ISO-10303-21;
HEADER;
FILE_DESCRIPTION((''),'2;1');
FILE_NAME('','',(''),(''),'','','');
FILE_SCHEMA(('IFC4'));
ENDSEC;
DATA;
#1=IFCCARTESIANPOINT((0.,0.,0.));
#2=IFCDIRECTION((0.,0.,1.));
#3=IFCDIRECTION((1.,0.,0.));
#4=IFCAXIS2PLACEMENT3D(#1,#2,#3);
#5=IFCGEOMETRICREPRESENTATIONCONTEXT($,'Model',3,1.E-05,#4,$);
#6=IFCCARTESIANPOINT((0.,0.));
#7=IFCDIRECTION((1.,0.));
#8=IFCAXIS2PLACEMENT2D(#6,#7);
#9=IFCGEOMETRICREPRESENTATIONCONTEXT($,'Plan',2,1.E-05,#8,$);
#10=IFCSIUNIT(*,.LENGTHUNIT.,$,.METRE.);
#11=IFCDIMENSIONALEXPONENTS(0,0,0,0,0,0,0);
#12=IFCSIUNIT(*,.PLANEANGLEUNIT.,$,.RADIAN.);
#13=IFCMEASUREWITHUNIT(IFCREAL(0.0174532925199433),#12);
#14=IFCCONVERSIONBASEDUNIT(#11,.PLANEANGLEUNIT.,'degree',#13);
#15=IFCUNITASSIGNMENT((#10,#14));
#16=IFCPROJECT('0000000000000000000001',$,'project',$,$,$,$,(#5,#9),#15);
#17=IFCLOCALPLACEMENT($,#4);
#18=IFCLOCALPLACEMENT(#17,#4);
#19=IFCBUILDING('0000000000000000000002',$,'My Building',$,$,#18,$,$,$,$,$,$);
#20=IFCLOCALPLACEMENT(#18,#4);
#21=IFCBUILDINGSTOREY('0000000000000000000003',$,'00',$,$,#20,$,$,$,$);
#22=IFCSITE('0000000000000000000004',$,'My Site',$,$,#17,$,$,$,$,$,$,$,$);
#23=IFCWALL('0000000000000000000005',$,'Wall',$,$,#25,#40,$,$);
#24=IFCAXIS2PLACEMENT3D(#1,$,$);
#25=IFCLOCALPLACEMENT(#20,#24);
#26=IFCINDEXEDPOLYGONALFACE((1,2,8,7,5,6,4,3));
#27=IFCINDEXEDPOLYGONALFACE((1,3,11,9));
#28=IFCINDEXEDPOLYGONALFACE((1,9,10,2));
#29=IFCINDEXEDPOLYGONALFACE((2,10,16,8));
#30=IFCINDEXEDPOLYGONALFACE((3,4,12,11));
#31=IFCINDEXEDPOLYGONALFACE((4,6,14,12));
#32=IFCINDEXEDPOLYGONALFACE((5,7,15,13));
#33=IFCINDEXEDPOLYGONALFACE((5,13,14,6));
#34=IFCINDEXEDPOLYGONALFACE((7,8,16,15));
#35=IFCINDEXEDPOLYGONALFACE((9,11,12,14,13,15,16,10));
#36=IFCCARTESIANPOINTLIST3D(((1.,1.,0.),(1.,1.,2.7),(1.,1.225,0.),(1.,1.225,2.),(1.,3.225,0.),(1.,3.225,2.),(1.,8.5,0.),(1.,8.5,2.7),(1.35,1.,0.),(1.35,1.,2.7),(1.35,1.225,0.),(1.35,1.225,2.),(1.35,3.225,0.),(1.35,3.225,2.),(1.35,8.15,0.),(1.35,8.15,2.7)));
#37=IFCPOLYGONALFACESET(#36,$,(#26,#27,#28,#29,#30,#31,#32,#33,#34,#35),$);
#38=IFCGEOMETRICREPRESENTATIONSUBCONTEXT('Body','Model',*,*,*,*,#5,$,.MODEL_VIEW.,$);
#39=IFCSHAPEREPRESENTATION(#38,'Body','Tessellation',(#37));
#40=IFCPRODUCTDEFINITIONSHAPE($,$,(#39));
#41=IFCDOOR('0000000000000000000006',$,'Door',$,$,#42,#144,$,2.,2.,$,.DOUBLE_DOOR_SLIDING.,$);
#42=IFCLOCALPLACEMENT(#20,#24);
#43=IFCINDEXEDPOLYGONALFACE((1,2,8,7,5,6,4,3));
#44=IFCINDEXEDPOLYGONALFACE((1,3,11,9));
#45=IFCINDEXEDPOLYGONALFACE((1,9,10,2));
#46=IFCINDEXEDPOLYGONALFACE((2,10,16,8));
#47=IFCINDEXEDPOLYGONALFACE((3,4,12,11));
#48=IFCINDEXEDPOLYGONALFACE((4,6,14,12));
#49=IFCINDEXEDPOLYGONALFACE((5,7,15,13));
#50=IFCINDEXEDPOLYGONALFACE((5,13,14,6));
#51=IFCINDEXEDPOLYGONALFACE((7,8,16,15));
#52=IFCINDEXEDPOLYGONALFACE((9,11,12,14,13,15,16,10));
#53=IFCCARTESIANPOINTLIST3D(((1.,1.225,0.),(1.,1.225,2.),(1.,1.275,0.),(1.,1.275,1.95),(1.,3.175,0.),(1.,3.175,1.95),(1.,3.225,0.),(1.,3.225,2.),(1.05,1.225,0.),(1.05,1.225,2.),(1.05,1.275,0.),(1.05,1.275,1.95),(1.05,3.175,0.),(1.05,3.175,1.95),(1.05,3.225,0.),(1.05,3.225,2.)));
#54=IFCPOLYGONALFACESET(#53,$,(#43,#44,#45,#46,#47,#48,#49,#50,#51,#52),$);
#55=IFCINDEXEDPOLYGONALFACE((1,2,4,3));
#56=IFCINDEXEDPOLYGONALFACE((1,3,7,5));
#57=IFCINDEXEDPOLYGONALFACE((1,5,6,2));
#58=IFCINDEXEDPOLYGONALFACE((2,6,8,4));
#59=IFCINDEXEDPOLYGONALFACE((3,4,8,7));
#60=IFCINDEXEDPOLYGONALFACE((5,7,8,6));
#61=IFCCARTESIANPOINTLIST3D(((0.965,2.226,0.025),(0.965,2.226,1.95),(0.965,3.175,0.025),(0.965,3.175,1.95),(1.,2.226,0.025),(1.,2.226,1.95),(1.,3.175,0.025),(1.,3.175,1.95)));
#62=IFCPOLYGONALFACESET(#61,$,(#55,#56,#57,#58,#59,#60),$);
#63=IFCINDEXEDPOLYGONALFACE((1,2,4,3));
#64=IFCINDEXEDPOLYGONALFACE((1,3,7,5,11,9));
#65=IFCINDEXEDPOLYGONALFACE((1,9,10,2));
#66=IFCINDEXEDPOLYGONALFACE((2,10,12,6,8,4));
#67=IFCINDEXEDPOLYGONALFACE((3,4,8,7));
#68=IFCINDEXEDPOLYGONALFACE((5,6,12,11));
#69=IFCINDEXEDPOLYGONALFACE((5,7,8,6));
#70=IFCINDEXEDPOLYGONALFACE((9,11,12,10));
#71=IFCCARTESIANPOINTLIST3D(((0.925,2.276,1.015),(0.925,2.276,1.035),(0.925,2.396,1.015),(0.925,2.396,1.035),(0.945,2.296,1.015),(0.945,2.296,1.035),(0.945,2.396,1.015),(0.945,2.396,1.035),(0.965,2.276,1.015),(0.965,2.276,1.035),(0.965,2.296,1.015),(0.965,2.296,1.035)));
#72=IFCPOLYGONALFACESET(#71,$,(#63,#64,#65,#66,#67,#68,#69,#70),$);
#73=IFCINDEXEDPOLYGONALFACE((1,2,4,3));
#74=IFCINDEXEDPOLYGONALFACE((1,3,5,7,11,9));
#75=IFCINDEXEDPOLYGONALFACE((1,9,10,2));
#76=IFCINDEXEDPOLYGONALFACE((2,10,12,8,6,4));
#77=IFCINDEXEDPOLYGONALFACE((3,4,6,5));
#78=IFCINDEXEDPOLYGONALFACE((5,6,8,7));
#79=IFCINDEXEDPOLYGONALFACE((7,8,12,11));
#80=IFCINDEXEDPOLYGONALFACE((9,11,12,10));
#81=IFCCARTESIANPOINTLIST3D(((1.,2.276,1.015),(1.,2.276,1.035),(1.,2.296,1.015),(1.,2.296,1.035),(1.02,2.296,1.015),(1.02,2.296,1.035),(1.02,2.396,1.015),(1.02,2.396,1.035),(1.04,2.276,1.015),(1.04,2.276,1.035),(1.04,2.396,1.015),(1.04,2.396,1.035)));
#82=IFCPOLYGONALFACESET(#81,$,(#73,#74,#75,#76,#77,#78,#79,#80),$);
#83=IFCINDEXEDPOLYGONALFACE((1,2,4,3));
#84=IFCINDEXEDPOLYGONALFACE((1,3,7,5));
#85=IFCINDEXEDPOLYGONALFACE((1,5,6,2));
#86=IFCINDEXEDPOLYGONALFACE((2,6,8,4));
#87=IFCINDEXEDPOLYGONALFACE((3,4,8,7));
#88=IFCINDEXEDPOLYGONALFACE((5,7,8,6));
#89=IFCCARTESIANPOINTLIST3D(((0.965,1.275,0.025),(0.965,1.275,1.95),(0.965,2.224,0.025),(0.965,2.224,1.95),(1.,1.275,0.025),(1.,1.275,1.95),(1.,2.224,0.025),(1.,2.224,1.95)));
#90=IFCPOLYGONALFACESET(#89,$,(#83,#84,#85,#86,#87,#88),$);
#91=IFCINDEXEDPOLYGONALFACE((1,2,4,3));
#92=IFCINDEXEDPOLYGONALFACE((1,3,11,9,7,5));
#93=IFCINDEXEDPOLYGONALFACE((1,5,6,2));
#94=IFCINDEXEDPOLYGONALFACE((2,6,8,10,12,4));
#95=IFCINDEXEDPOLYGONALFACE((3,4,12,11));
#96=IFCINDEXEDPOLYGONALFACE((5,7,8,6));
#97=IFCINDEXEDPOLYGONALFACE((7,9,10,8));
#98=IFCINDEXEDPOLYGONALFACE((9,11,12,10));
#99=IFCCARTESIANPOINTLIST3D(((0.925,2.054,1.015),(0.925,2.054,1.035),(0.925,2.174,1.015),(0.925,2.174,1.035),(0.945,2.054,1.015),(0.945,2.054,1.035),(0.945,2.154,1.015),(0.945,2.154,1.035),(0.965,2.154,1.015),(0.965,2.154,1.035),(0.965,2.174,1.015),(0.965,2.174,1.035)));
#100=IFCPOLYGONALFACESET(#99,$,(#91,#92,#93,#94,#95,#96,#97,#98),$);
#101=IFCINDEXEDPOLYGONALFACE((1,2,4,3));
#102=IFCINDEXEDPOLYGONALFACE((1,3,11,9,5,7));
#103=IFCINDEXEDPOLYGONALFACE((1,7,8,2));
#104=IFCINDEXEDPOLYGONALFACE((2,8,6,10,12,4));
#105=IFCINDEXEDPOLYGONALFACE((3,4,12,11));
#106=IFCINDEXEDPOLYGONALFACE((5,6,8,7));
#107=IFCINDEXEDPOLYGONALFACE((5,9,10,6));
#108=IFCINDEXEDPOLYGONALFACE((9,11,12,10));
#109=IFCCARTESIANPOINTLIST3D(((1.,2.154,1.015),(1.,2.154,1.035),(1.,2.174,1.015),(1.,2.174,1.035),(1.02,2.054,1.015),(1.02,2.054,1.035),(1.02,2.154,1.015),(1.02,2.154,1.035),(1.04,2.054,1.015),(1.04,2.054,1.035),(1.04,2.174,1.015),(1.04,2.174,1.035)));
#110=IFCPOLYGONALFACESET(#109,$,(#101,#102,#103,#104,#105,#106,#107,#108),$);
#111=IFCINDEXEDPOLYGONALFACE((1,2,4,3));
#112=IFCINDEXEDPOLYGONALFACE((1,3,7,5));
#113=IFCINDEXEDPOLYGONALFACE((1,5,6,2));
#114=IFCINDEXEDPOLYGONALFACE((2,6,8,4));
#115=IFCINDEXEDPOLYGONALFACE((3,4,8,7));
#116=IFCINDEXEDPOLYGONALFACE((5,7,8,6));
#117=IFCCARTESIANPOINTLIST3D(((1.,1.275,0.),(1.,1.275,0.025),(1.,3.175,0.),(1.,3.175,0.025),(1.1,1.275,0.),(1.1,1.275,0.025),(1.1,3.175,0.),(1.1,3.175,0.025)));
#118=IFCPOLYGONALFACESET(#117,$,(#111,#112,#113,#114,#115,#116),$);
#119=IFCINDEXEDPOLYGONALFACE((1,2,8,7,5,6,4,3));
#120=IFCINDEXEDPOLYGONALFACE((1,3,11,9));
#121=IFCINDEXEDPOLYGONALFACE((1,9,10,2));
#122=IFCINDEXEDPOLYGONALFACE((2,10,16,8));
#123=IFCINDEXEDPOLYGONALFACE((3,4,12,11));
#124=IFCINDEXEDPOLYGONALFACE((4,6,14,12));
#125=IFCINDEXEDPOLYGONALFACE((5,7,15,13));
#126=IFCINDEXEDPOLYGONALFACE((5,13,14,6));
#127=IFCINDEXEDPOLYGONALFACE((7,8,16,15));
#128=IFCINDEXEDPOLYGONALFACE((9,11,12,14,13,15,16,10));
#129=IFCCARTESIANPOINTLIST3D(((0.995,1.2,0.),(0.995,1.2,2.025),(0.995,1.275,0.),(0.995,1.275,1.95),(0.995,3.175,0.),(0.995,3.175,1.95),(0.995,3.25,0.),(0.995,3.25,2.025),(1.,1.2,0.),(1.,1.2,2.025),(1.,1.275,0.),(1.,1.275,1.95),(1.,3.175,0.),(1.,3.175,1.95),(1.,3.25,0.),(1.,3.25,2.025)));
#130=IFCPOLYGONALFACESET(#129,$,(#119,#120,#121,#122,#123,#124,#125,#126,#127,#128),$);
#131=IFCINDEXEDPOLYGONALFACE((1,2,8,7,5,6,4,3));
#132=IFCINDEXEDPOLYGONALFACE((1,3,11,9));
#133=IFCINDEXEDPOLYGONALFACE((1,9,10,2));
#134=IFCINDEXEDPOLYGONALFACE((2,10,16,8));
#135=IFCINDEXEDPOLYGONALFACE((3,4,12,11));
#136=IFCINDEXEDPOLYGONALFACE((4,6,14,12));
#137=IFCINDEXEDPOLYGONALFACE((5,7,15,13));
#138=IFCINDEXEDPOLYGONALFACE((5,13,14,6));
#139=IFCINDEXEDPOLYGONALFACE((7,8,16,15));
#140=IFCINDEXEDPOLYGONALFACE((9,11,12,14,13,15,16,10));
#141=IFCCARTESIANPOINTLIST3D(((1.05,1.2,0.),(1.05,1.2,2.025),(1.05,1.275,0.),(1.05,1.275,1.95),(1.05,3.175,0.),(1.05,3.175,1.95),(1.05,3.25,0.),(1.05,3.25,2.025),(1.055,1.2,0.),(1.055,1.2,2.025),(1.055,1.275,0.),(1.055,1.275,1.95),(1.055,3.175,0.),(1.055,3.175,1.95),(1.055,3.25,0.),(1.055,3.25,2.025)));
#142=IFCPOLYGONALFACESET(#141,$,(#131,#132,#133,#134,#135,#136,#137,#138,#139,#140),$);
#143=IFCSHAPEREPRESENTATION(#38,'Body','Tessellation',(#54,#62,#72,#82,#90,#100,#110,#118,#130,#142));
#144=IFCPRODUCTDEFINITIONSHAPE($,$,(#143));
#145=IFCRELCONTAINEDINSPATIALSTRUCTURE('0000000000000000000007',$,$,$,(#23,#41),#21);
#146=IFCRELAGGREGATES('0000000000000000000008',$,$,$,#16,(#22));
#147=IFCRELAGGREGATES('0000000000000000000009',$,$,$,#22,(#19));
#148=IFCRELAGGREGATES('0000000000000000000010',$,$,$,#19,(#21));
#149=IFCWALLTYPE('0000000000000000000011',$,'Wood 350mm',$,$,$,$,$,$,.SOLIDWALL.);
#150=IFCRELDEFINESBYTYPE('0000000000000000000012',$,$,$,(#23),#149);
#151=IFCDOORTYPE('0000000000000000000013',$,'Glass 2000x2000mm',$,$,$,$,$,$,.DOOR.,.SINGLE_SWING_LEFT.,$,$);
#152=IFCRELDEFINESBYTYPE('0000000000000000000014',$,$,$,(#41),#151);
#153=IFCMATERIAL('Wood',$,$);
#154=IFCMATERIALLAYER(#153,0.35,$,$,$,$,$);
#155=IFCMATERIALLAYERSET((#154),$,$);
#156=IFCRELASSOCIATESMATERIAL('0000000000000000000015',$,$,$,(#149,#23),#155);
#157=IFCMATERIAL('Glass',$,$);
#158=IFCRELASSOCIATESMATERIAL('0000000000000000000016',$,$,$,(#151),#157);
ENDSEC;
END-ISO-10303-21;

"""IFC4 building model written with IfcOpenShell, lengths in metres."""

from ifc_helpers import new_model, entity, si_unit, converted_unit, frame, origin_with_axes, origin_2d_with_axis, place, context, subcontext, project, spatial, line, indexed_curve, outline, extrude, clip, halfspace, shape, source, transform, mapped, material, layer, layer_set, layer_usage, type_object, type_shapes, element, fill, save


model = new_model("IFC4")

# Units and contexts
model_context = context("Model", 3, precision=1e-05, world=origin_with_axes())
plan_context = context("Plan", 2, precision=1e-05, world=origin_2d_with_axis())
body_context_1 = subcontext(model_context, "Body", "Model", "MODEL_VIEW")
body_context_2 = subcontext(plan_context, "Body", "Plan", "PLAN_VIEW")
ifc_project = project(units=[si_unit("LENGTHUNIT", "METRE"), converted_unit("PLANEANGLEUNIT", "degree", entity("IfcReal", 0.0174532925199433), si_unit("PLANEANGLEUNIT", "RADIAN"), dimensions=[0, 0, 0, 0, 0, 0, 0])], contexts=[model_context, plan_context])

# Site, building, storey
site_placement = place(None, origin_with_axes())
site = spatial("IfcSite", under=ifc_project, at=site_placement, Name="My Site")
building_placement = place(site_placement, origin_with_axes())
building = spatial("IfcBuilding", under=site, at=building_placement, Name="My Building")
storey_placement = place(building_placement, origin_with_axes())
storey = spatial("IfcBuildingStorey", under=building, at=storey_placement, Name="00")

# Shared definitions
ifc_material_1 = material(Name="Wood")

# Shared definitions
ifc_layer_1 = layer(ifc_material_1, 0.35)
ifc_layer_set_1 = layer_set([ifc_layer_1])
wall_type_1 = type_object("IfcWallType", Name="Wood 350mm", PredefinedType="SOLIDWALL", material=ifc_layer_set_1)
ifc_material_2 = material(Name="Glass")

# Wall, opening, door
ifc_layer_usage_1 = layer_usage(ifc_layer_set_1, "AXIS2", "POSITIVE", 0.0)
wall_1_placement = place(storey_placement, frame((1.0, 8.5, 0.0), z_axis=(0.0, 0.0, 1.0), x_axis=(0.0, -1.0, 0.0)))
wall_1 = element("IfcWall", 1, at=wall_1_placement, inside=storey, type_object=wall_type_1, material=ifc_layer_usage_1, Name="Wall", context=body_context_1, shape_type="Clipping", body=[
    clip(extrude(outline(indexed_curve([(0.0, 0.0), (0.0, 0.35), (7.5, 0.35), (7.5, 0.0), (0.0, 0.0)], self_intersect=False)), origin_with_axes(), (0.0, 0.0, 1.0), 2.7), halfspace(frame((0.0, 0.0, 0.0), z_axis=(-0.707107, 0.707107, 0.0), x_axis=(0.707107, 0.707106, 0.0)), False)),
])
shared_shape_1 = source(origin_with_axes(), body_context_1, "Body", "SweptSolid", [
    extrude(outline(indexed_curve([(0.0, 0.0), (2.0, 0.0), (2.0, 2.0), (0.0, 2.0)], segments=[line(1, 2, 3, 4, 1)])), frame((0.0, -0.6, 0.0), z_axis=(0.0, -1.0, 0.0), x_axis=(1.0, 0.0, 0.0)), (0.0, 0.0, -1.0), 1.2),
])
opening_1_placement = place(wall_1_placement, frame((5.275, 0.0, 0.0), z_axis=(0.0, 0.0, 1.0), x_axis=(1.0, 0.0, 0.0)))
opening_1 = element("IfcOpeningElement", 2, at=opening_1_placement, cuts=wall_1, PredefinedType="OPENING", context=body_context_1, shape_type="MappedRepresentation", body=[
    mapped(shared_shape_1, transform((0.0, 0.0, 0.0), x_axis=(1.0, 0.0, 0.0), y_axis=(0.0, 1.0, 0.0), z_axis=(0.0, 0.0, 1.0), scale=1.0)),
])
door_type_1 = type_object("IfcDoorType", Name="Glass 2000x2000mm", OperationType="SINGLE_SWING_LEFT", PredefinedType="DOOR", material=ifc_material_2)
shared_shape_2 = source(origin_with_axes(), body_context_1, "Body", "SweptSolid", [
    extrude(outline(indexed_curve([(0.0, 0.0), (0.0, 2.0), (2.0, 2.0), (2.0, 0.0), (1.95, 0.0), (1.95, 1.95), (0.05, 1.95), (0.05, 0.0)], segments=[line(1, 2, 3, 4, 5, 6, 7, 8, 1)])), frame((0.0, 0.0, 0.0), z_axis=(0.0, -1.0, 0.0), x_axis=(1.0, 0.0, 0.0)), (0.0, 0.0, -1.0), 0.05),
    extrude(outline(indexed_curve([(0.0, 0.0), (0.949, 0.0), (0.949, 0.035), (0.0, 0.035)], segments=[line(1, 2, 3, 4, 1)])), frame((0.05, -0.035, 0.025), z_axis=(0.0, 0.0, 1.0), x_axis=(1.0, 0.0, 0.0)), (0.0, 0.0, 1.0), 1.925),
    extrude(outline(indexed_curve([(0.0, 0.0), (0.0, -0.04), (-0.12, -0.04), (-0.12, -0.02), (-0.02, -0.02), (-0.02, 0.0)], segments=[line(1, 2, 3, 4, 5, 6, 1)])), frame((0.949, -0.035, 1.015), z_axis=(0.0, 0.0, 1.0), x_axis=(1.0, 0.0, 0.0)), (0.0, 0.0, 1.0), 0.02),
    extrude(outline(indexed_curve([(0.0, 0.0), (0.0, 0.04), (-0.12, 0.04), (-0.12, 0.02), (-0.02, 0.02), (-0.02, 0.0)], segments=[line(1, 2, 3, 4, 5, 6, 1)])), frame((0.949, 0.0, 1.015), z_axis=(0.0, 0.0, 1.0), x_axis=(1.0, 0.0, 0.0)), (0.0, 0.0, 1.0), 0.02),
    extrude(outline(indexed_curve([(0.0, 0.0), (-0.949, 0.0), (-0.949, 0.035), (0.0, 0.035)], segments=[line(1, 2, 3, 4, 1)])), frame((1.95, -0.035, 0.025), z_axis=(0.0, 0.0, 1.0), x_axis=(1.0, 0.0, 0.0)), (0.0, 0.0, 1.0), 1.925),
    extrude(outline(indexed_curve([(0.0, 0.0), (0.0, -0.04), (0.12, -0.04), (0.12, -0.02), (0.02, -0.02), (0.02, 0.0)], segments=[line(1, 2, 3, 4, 5, 6, 1)])), frame((1.051, -0.035, 1.015), z_axis=(0.0, 0.0, 1.0), x_axis=(1.0, 0.0, 0.0)), (0.0, 0.0, 1.0), 0.02),
    extrude(outline(indexed_curve([(0.0, 0.0), (0.0, 0.04), (0.12, 0.04), (0.12, 0.02), (0.02, 0.02), (0.02, 0.0)], segments=[line(1, 2, 3, 4, 5, 6, 1)])), frame((1.051, 0.0, 1.015), z_axis=(0.0, 0.0, 1.0), x_axis=(1.0, 0.0, 0.0)), (0.0, 0.0, 1.0), 0.02),
    extrude(outline(indexed_curve([(0.0, 0.0), (1.9, 0.0), (1.9, 0.1), (0.0, 0.1)], segments=[line(1, 2, 3, 4, 1)])), frame((0.05, 0.0, 0.0), z_axis=(0.0, 0.0, 1.0), x_axis=(1.0, 0.0, 0.0)), (0.0, 0.0, 1.0), 0.025),
    extrude(outline(indexed_curve([(0.0, 0.0), (0.0, 2.025), (2.05, 2.025), (2.05, 0.0), (1.975, 0.0), (1.975, 1.95), (0.075, 1.95), (0.075, 0.0)], segments=[line(1, 2, 3, 4, 5, 6, 7, 8, 1)])), frame((-0.025, -0.005, 0.0), z_axis=(0.0, -1.0, 0.0), x_axis=(1.0, 0.0, 0.0)), (0.0, 0.0, -1.0), 0.005),
    extrude(outline(indexed_curve([(0.0, 0.0), (0.0, 2.025), (2.05, 2.025), (2.05, 0.0), (1.975, 0.0), (1.975, 1.95), (0.075, 1.95), (0.075, 0.0)], segments=[line(1, 2, 3, 4, 5, 6, 7, 8, 1)])), frame((-0.025, 0.05, 0.0), z_axis=(0.0, -1.0, 0.0), x_axis=(1.0, 0.0, 0.0)), (0.0, 0.0, -1.0), 0.005),
])
shared_shape_3 = source(origin_with_axes(), body_context_2, "Body", "Curve2D", [
    entity("IfcIndexedPolyCurve", entity("IfcCartesianPointList2D", [[0.0, 0.0], [0.05, 0.0], [0.05, 0.05], [0.0, 0.05]]), [entity("IfcLineIndex", [1, 2, 3, 4, 1])]),
    entity("IfcIndexedPolyCurve", entity("IfcCartesianPointList2D", [[2.0, 0.0], [1.95, 0.0], [1.95, 0.05], [2.0, 0.05]]), [entity("IfcLineIndex", [1, 2, 3, 4, 1])]),
    entity("IfcIndexedPolyCurve", entity("IfcCartesianPointList2D", [[-0.425, -0.035], [0.525, -0.035], [0.525, 0.0], [-0.425, 0.0]]), [entity("IfcLineIndex", [1, 2, 3, 4, 1])]),
    entity("IfcIndexedPolyCurve", entity("IfcCartesianPointList2D", [[2.425, -0.035], [1.475, -0.035], [1.475, 0.0], [2.425, 0.0]]), [entity("IfcLineIndex", [1, 2, 3, 4, 1])]),
])
type_shapes(door_type_1, [shared_shape_2, shared_shape_3])
door_1_placement = place(opening_1_placement, frame((0.0, 0.0, 0.0), z_axis=(0.0, 0.0, 1.0), x_axis=(1.0, 0.0, 0.0)))
door_1 = element("IfcDoor", 3, at=door_1_placement, inside=storey, type_object=door_type_1, Name="Door", OperationType="DOUBLE_DOOR_SLIDING", OverallHeight=2.0, OverallWidth=2.0, shapes=[
    shape(body_context_1, "Body", "MappedRepresentation", [mapped(shared_shape_2, transform((0.0, 0.0, 0.0), x_axis=(1.0, 0.0, 0.0), y_axis=(0.0, 1.0, 0.0), z_axis=(0.0, 0.0, 1.0), scale=1.0))]),
    shape(body_context_2, "Body", "MappedRepresentation", [mapped(shared_shape_3, transform((0.0, 0.0, 0.0), x_axis=(1.0, 0.0, 0.0), y_axis=(0.0, 1.0, 0.0), z_axis=(0.0, 0.0, 1.0), scale=1.0))]),
])
fill(opening_1, door_1)

save(model, "model.ifc")
